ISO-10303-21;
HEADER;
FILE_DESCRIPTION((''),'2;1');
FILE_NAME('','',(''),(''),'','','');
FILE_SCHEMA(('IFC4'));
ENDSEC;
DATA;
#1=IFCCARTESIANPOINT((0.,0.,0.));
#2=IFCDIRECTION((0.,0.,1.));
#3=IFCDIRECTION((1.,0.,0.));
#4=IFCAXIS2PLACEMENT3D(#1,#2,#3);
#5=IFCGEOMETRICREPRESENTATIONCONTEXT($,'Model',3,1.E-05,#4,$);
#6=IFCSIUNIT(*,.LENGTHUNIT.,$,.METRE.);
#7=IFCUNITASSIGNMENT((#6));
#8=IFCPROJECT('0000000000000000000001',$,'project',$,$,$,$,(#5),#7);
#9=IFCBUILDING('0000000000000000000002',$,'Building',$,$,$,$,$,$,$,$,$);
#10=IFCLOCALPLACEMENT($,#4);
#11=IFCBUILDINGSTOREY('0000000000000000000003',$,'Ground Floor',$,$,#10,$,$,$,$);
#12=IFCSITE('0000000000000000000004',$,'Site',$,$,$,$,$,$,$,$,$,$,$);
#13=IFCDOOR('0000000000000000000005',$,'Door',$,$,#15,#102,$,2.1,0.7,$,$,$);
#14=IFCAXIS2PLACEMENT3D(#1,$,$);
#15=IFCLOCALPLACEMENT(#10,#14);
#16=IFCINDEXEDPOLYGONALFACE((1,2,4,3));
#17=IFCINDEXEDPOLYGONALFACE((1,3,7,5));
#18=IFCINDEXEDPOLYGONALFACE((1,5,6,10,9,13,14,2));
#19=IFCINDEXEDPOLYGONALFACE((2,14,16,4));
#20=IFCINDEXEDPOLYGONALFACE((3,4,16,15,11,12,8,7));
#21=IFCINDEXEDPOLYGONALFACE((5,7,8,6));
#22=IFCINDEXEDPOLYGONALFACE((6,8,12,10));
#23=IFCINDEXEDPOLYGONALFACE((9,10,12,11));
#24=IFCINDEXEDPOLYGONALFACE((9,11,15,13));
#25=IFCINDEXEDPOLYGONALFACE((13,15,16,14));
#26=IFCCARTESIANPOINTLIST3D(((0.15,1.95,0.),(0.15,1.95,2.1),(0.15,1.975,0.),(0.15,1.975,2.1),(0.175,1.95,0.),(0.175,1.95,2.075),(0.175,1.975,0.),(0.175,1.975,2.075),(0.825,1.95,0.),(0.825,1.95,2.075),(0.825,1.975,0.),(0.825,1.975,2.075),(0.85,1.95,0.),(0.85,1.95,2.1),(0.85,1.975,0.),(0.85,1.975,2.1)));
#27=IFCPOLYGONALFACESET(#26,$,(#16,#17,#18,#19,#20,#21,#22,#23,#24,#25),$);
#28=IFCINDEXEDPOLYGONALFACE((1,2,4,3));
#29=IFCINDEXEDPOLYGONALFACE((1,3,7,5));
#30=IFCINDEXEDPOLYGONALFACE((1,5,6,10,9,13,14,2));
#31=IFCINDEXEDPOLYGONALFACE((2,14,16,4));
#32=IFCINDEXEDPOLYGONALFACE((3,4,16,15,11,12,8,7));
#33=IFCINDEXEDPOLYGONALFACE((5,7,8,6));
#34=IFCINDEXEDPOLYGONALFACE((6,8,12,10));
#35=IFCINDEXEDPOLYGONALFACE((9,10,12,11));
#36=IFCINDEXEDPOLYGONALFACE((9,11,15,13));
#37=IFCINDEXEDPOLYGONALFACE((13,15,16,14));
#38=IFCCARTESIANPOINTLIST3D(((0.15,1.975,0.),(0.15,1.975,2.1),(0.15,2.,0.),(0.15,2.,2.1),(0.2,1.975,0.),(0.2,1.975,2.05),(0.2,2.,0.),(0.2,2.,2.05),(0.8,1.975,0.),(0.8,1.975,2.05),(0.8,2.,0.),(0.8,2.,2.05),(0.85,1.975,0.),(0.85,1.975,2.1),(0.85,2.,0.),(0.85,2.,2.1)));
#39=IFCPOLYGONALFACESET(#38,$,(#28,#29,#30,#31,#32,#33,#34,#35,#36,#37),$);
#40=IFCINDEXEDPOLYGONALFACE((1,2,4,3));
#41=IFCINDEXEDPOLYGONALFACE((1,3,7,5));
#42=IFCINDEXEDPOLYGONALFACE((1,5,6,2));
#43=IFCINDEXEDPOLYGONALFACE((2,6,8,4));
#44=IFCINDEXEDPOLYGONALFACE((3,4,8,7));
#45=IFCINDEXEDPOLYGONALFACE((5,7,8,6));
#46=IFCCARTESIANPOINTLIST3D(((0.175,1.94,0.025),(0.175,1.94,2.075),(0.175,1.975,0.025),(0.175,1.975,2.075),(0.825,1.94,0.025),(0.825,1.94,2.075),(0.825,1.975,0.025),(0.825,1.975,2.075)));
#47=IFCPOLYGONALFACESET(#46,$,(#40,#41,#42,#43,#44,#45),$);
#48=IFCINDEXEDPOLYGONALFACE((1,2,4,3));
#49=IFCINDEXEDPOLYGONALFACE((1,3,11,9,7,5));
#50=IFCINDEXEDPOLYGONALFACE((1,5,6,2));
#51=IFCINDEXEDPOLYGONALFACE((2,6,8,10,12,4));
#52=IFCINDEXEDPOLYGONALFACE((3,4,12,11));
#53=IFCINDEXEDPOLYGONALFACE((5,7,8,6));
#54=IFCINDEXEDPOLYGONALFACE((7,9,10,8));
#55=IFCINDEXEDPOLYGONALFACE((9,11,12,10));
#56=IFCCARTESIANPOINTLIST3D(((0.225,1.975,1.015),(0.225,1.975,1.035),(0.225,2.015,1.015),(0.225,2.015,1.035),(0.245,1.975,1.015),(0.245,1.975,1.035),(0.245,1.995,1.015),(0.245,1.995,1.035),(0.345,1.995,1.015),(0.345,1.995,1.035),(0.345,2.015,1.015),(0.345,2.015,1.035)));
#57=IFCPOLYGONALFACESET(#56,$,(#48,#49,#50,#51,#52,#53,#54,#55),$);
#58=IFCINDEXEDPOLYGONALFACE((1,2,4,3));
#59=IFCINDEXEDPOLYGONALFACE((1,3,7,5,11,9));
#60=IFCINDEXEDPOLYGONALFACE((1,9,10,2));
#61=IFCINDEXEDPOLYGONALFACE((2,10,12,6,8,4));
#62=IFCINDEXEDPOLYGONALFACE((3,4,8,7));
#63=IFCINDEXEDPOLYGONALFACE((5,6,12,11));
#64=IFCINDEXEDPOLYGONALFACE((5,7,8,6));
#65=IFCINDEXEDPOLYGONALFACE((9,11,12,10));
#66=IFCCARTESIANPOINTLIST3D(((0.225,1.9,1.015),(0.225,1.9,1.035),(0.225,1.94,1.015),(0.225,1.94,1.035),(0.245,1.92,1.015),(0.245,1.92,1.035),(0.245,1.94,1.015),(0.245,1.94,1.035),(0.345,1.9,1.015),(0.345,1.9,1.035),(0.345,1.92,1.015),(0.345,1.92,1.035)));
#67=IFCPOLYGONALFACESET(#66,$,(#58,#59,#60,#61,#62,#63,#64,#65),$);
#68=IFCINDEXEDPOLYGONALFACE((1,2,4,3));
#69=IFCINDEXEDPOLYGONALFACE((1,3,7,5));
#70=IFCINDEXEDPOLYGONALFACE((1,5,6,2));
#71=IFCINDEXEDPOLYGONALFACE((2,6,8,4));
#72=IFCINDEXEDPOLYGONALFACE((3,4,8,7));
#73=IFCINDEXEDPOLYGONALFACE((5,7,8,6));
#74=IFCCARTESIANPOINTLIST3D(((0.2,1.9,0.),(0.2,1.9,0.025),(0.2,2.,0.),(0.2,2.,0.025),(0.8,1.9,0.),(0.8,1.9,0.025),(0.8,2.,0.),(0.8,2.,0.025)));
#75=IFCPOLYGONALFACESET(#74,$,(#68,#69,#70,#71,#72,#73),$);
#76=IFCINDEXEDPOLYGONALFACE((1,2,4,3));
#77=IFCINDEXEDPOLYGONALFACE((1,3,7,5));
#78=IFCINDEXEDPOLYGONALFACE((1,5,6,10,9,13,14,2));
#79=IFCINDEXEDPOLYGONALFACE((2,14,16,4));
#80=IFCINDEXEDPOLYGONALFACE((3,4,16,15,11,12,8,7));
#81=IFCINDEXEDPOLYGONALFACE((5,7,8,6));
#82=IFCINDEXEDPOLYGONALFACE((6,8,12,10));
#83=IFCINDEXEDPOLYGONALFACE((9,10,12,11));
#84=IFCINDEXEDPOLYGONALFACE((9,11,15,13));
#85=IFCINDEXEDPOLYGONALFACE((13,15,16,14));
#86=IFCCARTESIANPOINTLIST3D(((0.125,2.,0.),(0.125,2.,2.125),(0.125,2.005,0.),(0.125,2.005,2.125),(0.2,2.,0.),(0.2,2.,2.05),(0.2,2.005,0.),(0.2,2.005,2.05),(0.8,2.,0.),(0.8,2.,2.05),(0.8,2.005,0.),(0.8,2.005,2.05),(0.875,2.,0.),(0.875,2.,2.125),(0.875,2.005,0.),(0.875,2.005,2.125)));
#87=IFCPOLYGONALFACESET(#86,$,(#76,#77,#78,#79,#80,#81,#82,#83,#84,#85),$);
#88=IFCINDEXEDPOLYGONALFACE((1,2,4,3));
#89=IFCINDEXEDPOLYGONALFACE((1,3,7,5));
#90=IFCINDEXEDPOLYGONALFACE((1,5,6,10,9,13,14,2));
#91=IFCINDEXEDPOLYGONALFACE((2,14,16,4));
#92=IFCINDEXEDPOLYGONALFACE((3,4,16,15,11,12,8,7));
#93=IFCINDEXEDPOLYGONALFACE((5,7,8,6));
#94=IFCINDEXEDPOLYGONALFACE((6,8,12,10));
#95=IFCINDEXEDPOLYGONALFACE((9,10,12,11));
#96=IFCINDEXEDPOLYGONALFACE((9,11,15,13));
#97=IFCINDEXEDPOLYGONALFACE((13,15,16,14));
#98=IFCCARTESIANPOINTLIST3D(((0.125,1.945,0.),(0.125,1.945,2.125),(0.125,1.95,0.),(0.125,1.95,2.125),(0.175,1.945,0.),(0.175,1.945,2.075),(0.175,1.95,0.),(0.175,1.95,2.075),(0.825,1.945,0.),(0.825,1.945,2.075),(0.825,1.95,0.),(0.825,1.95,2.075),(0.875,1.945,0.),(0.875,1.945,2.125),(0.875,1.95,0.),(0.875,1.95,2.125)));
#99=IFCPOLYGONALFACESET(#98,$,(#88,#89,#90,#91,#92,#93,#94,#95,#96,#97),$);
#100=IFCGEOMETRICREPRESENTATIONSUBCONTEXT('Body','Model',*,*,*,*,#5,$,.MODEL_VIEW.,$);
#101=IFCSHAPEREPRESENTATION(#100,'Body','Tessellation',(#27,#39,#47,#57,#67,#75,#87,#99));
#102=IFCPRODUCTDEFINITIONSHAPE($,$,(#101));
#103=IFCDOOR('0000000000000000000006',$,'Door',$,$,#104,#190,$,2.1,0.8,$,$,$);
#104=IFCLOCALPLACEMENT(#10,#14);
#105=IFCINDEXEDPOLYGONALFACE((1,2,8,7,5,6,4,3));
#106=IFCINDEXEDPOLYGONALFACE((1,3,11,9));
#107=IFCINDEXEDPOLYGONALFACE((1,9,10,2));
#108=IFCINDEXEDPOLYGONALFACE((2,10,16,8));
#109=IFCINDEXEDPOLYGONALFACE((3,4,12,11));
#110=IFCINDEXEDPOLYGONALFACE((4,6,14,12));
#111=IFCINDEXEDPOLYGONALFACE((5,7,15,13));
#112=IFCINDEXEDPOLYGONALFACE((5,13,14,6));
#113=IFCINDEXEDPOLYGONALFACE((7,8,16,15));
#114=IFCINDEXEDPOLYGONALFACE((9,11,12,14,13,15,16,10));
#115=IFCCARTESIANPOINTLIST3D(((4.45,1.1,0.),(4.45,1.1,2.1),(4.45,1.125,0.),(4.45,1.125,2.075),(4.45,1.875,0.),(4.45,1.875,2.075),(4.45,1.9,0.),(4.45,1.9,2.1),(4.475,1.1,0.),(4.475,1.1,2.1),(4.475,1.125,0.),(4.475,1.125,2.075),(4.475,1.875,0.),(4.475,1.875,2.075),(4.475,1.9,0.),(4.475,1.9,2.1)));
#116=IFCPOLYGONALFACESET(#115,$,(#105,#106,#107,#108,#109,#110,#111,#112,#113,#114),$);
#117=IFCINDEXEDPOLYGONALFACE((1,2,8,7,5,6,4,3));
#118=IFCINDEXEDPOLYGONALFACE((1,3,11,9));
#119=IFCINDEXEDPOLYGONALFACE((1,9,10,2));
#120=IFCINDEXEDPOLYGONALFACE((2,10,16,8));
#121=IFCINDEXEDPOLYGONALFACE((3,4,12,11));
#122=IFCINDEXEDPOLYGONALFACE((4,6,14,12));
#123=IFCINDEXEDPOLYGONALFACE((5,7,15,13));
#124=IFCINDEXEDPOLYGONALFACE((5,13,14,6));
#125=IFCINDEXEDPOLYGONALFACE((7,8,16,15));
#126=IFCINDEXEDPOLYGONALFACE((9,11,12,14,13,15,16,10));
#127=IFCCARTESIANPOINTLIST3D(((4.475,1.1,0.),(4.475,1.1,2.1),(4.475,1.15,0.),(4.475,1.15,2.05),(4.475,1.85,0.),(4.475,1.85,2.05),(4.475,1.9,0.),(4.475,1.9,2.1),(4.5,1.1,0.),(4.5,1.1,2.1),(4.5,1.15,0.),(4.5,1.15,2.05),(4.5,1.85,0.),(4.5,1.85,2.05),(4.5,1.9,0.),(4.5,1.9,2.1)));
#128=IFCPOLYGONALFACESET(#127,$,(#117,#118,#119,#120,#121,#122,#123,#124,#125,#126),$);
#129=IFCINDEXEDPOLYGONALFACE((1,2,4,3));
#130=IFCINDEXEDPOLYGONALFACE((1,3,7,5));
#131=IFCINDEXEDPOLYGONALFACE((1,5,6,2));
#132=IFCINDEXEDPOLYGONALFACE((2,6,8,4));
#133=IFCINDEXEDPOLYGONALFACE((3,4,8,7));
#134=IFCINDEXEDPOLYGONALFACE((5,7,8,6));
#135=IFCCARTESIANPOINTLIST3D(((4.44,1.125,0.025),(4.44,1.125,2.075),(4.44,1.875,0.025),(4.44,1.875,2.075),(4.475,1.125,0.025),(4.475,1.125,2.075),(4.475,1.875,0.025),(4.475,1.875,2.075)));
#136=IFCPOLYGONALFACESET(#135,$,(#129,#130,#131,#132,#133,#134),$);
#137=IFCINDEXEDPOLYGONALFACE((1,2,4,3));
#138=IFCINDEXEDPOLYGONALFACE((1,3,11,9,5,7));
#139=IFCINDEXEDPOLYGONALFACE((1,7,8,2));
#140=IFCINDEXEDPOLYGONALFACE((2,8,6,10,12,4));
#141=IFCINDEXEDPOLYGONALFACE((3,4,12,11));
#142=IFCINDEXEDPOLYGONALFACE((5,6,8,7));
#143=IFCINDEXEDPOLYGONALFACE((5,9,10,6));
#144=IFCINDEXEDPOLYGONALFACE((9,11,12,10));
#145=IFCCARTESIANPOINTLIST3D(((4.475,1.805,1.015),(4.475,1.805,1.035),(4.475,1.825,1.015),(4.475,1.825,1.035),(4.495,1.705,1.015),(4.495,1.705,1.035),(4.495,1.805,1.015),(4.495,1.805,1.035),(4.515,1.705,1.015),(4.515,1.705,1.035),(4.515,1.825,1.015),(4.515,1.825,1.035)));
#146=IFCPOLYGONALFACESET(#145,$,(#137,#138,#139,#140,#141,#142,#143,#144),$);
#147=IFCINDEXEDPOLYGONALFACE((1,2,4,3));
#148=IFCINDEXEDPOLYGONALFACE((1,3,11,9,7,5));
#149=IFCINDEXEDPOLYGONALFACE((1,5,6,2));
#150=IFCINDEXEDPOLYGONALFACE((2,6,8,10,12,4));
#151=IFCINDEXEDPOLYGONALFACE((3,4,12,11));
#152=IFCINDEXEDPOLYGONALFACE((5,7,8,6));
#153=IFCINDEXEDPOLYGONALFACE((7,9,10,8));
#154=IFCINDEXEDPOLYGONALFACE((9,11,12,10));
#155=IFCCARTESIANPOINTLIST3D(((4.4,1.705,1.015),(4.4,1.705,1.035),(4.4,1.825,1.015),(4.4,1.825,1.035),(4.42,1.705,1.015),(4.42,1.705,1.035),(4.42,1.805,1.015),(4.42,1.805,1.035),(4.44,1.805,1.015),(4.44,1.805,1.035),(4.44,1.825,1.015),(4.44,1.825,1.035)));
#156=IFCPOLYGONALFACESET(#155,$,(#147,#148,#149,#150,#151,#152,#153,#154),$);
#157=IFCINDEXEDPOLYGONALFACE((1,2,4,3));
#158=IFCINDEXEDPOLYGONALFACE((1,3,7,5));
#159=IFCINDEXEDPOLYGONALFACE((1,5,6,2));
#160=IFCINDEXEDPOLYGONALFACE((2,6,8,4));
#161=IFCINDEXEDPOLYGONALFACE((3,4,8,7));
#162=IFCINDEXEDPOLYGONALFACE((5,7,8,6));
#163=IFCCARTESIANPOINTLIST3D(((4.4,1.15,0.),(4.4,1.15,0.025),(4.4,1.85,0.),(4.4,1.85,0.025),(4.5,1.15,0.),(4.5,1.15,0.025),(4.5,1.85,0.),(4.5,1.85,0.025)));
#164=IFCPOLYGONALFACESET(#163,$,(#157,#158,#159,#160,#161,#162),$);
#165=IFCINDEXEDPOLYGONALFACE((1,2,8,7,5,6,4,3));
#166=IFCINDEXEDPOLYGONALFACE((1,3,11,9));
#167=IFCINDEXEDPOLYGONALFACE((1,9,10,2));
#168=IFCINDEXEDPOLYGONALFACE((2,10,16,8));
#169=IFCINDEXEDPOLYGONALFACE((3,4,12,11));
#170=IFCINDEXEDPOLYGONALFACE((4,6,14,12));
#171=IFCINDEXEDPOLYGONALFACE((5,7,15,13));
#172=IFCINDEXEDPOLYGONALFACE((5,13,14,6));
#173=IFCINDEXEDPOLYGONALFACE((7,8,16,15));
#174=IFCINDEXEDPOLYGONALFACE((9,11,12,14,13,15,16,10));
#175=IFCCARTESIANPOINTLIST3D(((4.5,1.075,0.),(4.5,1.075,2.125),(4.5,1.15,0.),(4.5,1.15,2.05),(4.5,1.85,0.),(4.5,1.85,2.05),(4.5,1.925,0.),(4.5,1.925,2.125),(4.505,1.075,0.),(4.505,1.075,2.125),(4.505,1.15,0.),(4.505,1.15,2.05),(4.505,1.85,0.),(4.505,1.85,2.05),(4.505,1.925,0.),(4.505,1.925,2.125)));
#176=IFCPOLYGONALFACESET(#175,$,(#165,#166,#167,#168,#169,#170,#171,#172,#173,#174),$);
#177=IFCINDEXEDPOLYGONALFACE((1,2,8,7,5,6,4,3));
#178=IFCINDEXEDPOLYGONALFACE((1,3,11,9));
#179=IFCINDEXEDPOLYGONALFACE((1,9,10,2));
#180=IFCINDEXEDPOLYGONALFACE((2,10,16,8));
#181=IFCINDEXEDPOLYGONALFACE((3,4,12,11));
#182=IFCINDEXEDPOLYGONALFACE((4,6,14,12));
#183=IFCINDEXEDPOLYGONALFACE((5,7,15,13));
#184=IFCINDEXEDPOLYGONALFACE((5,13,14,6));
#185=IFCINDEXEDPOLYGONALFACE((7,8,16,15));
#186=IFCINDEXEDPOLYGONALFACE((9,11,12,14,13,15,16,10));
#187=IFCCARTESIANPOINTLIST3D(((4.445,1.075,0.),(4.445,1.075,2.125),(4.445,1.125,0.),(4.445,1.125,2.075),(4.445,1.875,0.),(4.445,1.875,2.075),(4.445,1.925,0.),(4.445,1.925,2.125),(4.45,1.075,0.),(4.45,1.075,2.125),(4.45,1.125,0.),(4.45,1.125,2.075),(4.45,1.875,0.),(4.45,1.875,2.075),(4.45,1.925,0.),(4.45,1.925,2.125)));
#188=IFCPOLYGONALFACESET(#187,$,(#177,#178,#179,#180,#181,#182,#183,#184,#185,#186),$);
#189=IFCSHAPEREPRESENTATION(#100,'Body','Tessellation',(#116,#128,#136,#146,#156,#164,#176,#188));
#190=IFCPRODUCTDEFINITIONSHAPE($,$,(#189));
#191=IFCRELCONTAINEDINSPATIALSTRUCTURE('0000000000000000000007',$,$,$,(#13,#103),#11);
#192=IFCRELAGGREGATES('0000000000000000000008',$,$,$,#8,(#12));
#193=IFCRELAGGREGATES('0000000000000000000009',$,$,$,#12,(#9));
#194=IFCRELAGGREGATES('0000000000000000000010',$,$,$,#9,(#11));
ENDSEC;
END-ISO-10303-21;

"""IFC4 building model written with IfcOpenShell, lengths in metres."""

from ifc_helpers import new_model, si_unit, frame, origin_with_axes, place, context, subcontext, project, spatial, line, indexed_curve, outline, extrude, element, save


model = new_model("IFC4")

# Units and contexts
model_context = context("Model", 3, precision=1e-05, world=origin_with_axes())
body_context = subcontext(model_context, "Body", "Model", "MODEL_VIEW")
ifc_project = project(units=[si_unit("LENGTHUNIT", "METRE")], contexts=[model_context])

# Site, building, storey
site = spatial("IfcSite", under=ifc_project, Name="Site")
building = spatial("IfcBuilding", under=site, Name="Building")
storey_placement = place(None, origin_with_axes())
storey = spatial("IfcBuildingStorey", under=building, at=storey_placement, Name="Ground Floor")

# Doors
door_1_placement = place(storey_placement, frame((0.85, 2.0, 0.0), z_axis=(0.0, 0.0, 1.0), x_axis=(-1.0, 0.0, 0.0)))
element("IfcDoor", 1, at=door_1_placement, inside=storey, Name="Door", OverallHeight=2.1, OverallWidth=0.7, context=body_context, shape_type="SweptSolid", body=[
    extrude(outline(indexed_curve([(0.0, 0.0), (0.0, 2.1), (0.7, 2.1), (0.7, 0.0), (0.675, 0.0), (0.675, 2.075), (0.025, 2.075), (0.025, 0.0)], segments=[line(1, 2, 3, 4, 5, 6, 7, 8, 1)])), frame((0.0, 0.025, 0.0), z_axis=(0.0, -1.0, 0.0), x_axis=(1.0, 0.0, 0.0)), (0.0, 0.0, -1.0), 0.025),
    extrude(outline(indexed_curve([(0.0, 0.0), (0.0, 2.1), (0.7, 2.1), (0.7, 0.0), (0.65, 0.0), (0.65, 2.05), (0.05, 2.05), (0.05, 0.0)], segments=[line(1, 2, 3, 4, 5, 6, 7, 8, 1)])), frame((0.0, 0.0, 0.0), z_axis=(0.0, -1.0, 0.0), x_axis=(1.0, 0.0, 0.0)), (0.0, 0.0, -1.0), 0.025),
    extrude(outline(indexed_curve([(0.0, 0.0), (0.65, 0.0), (0.65, 0.035), (0.0, 0.035)], segments=[line(1, 2, 3, 4, 1)])), frame((0.025, 0.025, 0.025), z_axis=(0.0, 0.0, 1.0), x_axis=(1.0, 0.0, 0.0)), (0.0, 0.0, 1.0), 2.05),
    extrude(outline(indexed_curve([(0.0, 0.0), (0.0, -0.04), (-0.12, -0.04), (-0.12, -0.02), (-0.02, -0.02), (-0.02, 0.0)], segments=[line(1, 2, 3, 4, 5, 6, 1)])), frame((0.625, 0.025, 1.015), z_axis=(0.0, 0.0, 1.0), x_axis=(1.0, 0.0, 0.0)), (0.0, 0.0, 1.0), 0.02),
    extrude(outline(indexed_curve([(0.0, 0.0), (0.0, 0.04), (-0.12, 0.04), (-0.12, 0.02), (-0.02, 0.02), (-0.02, 0.0)], segments=[line(1, 2, 3, 4, 5, 6, 1)])), frame((0.625, 0.06, 1.015), z_axis=(0.0, 0.0, 1.0), x_axis=(1.0, 0.0, 0.0)), (0.0, 0.0, 1.0), 0.02),
    extrude(outline(indexed_curve([(0.0, 0.0), (0.6, 0.0), (0.6, 0.1), (0.0, 0.1)], segments=[line(1, 2, 3, 4, 1)])), frame((0.05, 0.0, 0.0), z_axis=(0.0, 0.0, 1.0), x_axis=(1.0, 0.0, 0.0)), (0.0, 0.0, 1.0), 0.025),
    extrude(outline(indexed_curve([(0.0, 0.0), (0.0, 2.125), (0.75, 2.125), (0.75, 0.0), (0.675, 0.0), (0.675, 2.05), (0.075, 2.05), (0.075, 0.0)], segments=[line(1, 2, 3, 4, 5, 6, 7, 8, 1)])), frame((-0.025, -0.005, 0.0), z_axis=(0.0, -1.0, 0.0), x_axis=(1.0, 0.0, 0.0)), (0.0, 0.0, -1.0), 0.005),
    extrude(outline(indexed_curve([(0.0, 0.0), (0.0, 2.125), (0.75, 2.125), (0.75, 0.0), (0.7, 0.0), (0.7, 2.075), (0.05, 2.075), (0.05, 0.0)], segments=[line(1, 2, 3, 4, 5, 6, 7, 8, 1)])), frame((-0.025, 0.05, 0.0), z_axis=(0.0, -1.0, 0.0), x_axis=(1.0, 0.0, 0.0)), (0.0, 0.0, -1.0), 0.005),
])
door_2_placement = place(storey_placement, frame((4.5, 1.1, 0.0), z_axis=(0.0, 0.0, 1.0), x_axis=(0.0, 1.0, 0.0)))
element("IfcDoor", 2, at=door_2_placement, inside=storey, Name="Door", OverallHeight=2.1, OverallWidth=0.8, context=body_context, shape_type="SweptSolid", body=[
    extrude(outline(indexed_curve([(0.0, 0.0), (0.0, 2.1), (0.8, 2.1), (0.8, 0.0), (0.775, 0.0), (0.775, 2.075), (0.025, 2.075), (0.025, 0.0)], segments=[line(1, 2, 3, 4, 5, 6, 7, 8, 1)])), frame((0.0, 0.025, 0.0), z_axis=(0.0, -1.0, 0.0), x_axis=(1.0, 0.0, 0.0)), (0.0, 0.0, -1.0), 0.025),
    extrude(outline(indexed_curve([(0.0, 0.0), (0.0, 2.1), (0.8, 2.1), (0.8, 0.0), (0.75, 0.0), (0.75, 2.05), (0.05, 2.05), (0.05, 0.0)], segments=[line(1, 2, 3, 4, 5, 6, 7, 8, 1)])), frame((0.0, 0.0, 0.0), z_axis=(0.0, -1.0, 0.0), x_axis=(1.0, 0.0, 0.0)), (0.0, 0.0, -1.0), 0.025),
    extrude(outline(indexed_curve([(0.0, 0.0), (0.75, 0.0), (0.75, 0.035), (0.0, 0.035)], segments=[line(1, 2, 3, 4, 1)])), frame((0.025, 0.025, 0.025), z_axis=(0.0, 0.0, 1.0), x_axis=(1.0, 0.0, 0.0)), (0.0, 0.0, 1.0), 2.05),
    extrude(outline(indexed_curve([(0.0, 0.0), (0.0, -0.04), (-0.12, -0.04), (-0.12, -0.02), (-0.02, -0.02), (-0.02, 0.0)], segments=[line(1, 2, 3, 4, 5, 6, 1)])), frame((0.725, 0.025, 1.015), z_axis=(0.0, 0.0, 1.0), x_axis=(1.0, 0.0, 0.0)), (0.0, 0.0, 1.0), 0.02),
    extrude(outline(indexed_curve([(0.0, 0.0), (0.0, 0.04), (-0.12, 0.04), (-0.12, 0.02), (-0.02, 0.02), (-0.02, 0.0)], segments=[line(1, 2, 3, 4, 5, 6, 1)])), frame((0.725, 0.06, 1.015), z_axis=(0.0, 0.0, 1.0), x_axis=(1.0, 0.0, 0.0)), (0.0, 0.0, 1.0), 0.02),
    extrude(outline(indexed_curve([(0.0, 0.0), (0.7, 0.0), (0.7, 0.1), (0.0, 0.1)], segments=[line(1, 2, 3, 4, 1)])), frame((0.05, 0.0, 0.0), z_axis=(0.0, 0.0, 1.0), x_axis=(1.0, 0.0, 0.0)), (0.0, 0.0, 1.0), 0.025),
    extrude(outline(indexed_curve([(0.0, 0.0), (0.0, 2.125), (0.85, 2.125), (0.85, 0.0), (0.775, 0.0), (0.775, 2.05), (0.075, 2.05), (0.075, 0.0)], segments=[line(1, 2, 3, 4, 5, 6, 7, 8, 1)])), frame((-0.025, -0.005, 0.0), z_axis=(0.0, -1.0, 0.0), x_axis=(1.0, 0.0, 0.0)), (0.0, 0.0, -1.0), 0.005),
    extrude(outline(indexed_curve([(0.0, 0.0), (0.0, 2.125), (0.85, 2.125), (0.85, 0.0), (0.8, 0.0), (0.8, 2.075), (0.05, 2.075), (0.05, 0.0)], segments=[line(1, 2, 3, 4, 5, 6, 7, 8, 1)])), frame((-0.025, 0.05, 0.0), z_axis=(0.0, -1.0, 0.0), x_axis=(1.0, 0.0, 0.0)), (0.0, 0.0, -1.0), 0.005),
])

save(model, "model.ifc")
